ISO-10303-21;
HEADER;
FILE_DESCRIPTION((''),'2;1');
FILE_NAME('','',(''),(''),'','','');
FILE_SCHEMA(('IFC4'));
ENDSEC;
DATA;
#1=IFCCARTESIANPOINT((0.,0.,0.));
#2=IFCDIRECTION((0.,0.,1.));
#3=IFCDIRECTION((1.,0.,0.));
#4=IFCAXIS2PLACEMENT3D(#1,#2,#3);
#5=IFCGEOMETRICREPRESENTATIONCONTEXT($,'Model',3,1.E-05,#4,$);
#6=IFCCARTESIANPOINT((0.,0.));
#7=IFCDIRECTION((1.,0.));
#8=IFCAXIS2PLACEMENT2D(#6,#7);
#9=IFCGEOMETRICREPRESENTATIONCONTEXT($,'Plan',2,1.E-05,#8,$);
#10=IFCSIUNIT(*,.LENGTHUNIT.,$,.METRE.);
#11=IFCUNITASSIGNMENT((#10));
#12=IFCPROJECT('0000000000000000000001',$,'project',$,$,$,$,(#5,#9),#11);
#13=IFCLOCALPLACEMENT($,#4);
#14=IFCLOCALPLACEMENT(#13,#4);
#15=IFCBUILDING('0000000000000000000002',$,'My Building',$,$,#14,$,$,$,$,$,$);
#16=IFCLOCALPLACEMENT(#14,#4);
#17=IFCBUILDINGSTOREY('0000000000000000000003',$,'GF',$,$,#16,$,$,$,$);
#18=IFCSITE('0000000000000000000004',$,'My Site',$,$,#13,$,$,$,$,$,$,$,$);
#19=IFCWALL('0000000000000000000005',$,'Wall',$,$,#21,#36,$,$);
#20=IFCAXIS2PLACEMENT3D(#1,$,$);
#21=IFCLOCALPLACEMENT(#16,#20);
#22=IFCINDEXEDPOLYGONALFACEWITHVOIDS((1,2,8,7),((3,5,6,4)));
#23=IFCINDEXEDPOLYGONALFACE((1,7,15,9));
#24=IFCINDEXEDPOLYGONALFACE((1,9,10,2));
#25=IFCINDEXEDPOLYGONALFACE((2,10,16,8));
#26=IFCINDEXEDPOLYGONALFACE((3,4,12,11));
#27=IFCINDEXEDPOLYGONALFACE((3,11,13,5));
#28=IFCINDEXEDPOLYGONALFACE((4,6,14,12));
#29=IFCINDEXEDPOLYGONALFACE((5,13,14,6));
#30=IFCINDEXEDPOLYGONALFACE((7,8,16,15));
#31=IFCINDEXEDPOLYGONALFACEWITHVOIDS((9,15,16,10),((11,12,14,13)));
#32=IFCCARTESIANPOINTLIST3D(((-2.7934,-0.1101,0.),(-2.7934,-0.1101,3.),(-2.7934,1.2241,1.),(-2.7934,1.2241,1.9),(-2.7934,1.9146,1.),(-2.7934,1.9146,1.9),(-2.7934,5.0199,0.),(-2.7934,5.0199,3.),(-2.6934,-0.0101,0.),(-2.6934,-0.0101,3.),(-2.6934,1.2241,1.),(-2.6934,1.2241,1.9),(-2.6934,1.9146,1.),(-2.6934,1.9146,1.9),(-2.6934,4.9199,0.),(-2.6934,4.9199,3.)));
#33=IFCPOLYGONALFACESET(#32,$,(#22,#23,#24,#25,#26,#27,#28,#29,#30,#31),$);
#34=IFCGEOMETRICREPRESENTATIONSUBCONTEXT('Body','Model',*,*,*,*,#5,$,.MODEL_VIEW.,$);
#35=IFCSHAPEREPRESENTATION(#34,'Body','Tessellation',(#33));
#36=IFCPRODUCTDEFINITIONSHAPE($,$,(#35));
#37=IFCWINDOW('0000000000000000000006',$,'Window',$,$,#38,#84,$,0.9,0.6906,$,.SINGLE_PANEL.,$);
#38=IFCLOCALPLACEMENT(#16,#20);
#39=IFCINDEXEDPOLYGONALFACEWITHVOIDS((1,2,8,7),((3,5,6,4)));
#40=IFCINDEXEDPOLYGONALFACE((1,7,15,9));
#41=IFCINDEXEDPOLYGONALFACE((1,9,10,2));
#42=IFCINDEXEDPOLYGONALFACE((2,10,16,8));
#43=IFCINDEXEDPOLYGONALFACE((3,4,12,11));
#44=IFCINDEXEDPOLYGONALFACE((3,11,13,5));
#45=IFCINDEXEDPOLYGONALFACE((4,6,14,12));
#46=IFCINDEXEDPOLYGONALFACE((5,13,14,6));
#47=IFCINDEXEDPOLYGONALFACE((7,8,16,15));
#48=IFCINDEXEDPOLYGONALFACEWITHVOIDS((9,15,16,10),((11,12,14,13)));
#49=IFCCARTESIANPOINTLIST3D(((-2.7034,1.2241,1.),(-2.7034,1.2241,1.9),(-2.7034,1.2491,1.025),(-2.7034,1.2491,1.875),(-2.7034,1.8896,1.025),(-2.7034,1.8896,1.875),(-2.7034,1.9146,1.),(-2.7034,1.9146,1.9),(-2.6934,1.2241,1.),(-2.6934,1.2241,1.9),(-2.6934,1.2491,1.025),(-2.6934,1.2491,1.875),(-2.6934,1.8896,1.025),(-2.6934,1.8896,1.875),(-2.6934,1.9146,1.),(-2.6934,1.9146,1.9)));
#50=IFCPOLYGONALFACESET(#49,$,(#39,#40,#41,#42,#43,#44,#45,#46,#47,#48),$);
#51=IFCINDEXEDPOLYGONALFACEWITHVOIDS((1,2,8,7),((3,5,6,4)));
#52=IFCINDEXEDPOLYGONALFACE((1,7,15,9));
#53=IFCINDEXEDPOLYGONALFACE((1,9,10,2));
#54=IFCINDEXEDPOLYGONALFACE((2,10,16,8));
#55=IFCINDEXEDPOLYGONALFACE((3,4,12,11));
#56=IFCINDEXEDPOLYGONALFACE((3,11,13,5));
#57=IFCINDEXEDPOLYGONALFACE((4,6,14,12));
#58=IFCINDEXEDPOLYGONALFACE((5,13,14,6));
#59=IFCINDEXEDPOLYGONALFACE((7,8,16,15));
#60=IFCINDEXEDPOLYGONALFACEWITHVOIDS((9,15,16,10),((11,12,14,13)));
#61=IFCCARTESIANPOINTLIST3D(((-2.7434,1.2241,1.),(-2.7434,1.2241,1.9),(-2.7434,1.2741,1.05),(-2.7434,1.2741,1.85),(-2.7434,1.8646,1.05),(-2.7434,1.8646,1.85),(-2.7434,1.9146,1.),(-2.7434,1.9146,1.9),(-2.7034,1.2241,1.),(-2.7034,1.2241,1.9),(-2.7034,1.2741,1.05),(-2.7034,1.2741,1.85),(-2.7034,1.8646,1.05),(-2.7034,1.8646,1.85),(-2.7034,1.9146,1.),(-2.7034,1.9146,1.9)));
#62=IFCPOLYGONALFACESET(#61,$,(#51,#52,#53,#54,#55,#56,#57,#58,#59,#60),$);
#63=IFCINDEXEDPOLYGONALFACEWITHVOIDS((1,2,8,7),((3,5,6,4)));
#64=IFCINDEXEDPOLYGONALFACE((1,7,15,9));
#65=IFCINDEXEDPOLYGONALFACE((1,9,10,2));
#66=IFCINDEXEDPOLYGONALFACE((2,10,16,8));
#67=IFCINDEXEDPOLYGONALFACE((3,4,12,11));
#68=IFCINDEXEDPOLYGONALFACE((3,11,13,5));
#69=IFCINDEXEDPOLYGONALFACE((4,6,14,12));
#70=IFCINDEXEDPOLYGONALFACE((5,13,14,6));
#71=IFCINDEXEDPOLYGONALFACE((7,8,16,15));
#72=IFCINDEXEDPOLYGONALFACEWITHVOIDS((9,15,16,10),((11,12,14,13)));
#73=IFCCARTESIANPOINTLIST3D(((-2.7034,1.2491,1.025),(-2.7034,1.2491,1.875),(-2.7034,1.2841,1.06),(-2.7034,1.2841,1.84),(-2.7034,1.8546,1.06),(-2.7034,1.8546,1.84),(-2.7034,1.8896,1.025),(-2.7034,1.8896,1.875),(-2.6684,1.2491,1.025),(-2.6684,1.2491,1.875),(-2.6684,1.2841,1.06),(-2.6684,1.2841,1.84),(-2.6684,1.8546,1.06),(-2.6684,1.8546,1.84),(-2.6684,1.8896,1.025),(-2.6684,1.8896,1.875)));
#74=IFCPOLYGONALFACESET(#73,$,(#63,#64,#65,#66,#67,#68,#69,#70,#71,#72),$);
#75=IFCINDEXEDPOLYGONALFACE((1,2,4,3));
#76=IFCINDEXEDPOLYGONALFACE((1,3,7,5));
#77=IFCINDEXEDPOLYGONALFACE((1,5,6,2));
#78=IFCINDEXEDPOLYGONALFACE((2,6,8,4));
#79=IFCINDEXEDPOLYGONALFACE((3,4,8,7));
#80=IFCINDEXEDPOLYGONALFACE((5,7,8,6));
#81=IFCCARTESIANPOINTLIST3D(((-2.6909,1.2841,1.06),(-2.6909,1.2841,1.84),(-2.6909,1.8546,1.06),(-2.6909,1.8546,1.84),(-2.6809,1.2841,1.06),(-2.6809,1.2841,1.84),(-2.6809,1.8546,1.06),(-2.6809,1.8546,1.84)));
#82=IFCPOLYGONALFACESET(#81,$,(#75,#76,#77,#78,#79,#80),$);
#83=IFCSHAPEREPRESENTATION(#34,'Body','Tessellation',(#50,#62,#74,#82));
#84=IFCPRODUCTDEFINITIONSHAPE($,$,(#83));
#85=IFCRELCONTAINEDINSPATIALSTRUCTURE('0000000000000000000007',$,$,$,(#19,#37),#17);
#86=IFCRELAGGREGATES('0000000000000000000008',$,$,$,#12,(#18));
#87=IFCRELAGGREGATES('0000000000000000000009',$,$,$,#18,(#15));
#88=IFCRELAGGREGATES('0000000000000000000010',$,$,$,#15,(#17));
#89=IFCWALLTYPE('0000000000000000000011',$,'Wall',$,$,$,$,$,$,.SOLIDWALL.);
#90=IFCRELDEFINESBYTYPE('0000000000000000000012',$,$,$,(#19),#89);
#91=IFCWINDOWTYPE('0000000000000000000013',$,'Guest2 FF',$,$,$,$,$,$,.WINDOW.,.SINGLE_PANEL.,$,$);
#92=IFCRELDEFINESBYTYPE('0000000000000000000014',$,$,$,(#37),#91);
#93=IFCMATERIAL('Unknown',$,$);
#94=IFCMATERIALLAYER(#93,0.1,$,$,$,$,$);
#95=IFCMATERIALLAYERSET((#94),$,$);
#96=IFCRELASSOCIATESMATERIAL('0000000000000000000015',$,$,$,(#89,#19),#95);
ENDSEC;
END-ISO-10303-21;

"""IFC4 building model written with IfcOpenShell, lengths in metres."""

from ifc_helpers import new_model, entity, si_unit, frame, origin_with_axes, origin_2d_with_axis, place, context, subcontext, project, spatial, line, indexed_curve, outline, extrude, shape, source, transform, mapped, material, layer, layer_set, layer_usage, type_object, type_shapes, element, fill, save


model = new_model("IFC4")

# Units and contexts
model_context = context("Model", 3, precision=1e-05, world=origin_with_axes())
plan_context = context("Plan", 2, precision=1e-05, world=origin_2d_with_axis())
body_context_1 = subcontext(model_context, "Body", "Model", "MODEL_VIEW")
body_context_2 = subcontext(plan_context, "Body", "Plan", "PLAN_VIEW")
ifc_project = project(units=[si_unit("LENGTHUNIT", "METRE")], contexts=[model_context, plan_context])

# Site, building, storey
site_placement = place(None, origin_with_axes())
site = spatial("IfcSite", under=ifc_project, at=site_placement, Name="My Site")
building_placement = place(site_placement, origin_with_axes())
building = spatial("IfcBuilding", under=site, at=building_placement, Name="My Building")
storey_placement = place(building_placement, origin_with_axes())
storey = spatial("IfcBuildingStorey", under=building, at=storey_placement, Name="GF")

# Shared definitions
ifc_material_1 = material(Name="Unknown")

# Shared definitions
ifc_layer_1 = layer(ifc_material_1, 0.1)
ifc_layer_set_1 = layer_set([ifc_layer_1])
wall_type = type_object("IfcWallType", Name="Wall", PredefinedType="SOLIDWALL", material=ifc_layer_set_1)

# Wall, opening, window
ifc_layer_usage_1 = layer_usage(ifc_layer_set_1, "AXIS2", "POSITIVE", 0.0)
wall_1_placement = place(storey_placement, frame((-2.7934, 5.0199, 0.0), z_axis=(0.0, 0.0, 1.0), x_axis=(0.0, -1.0, 0.0)))
wall_1 = element("IfcWall", 1, at=wall_1_placement, inside=storey, type_object=wall_type, material=ifc_layer_usage_1, Name="Wall", context=body_context_1, shape_type="SweptSolid", body=[
    extrude(outline(indexed_curve([(0.0, 0.0), (0.1, 0.1), (5.03, 0.1), (5.13, 0.0)], segments=[line(1, 2, 3, 4, 1)])), origin_with_axes(), (0.0, 0.0, 1.0), 3.0),
])
shared_shape_1 = source(origin_with_axes(), body_context_1, "Body", "SweptSolid", [
    extrude(outline(indexed_curve([(0.0, 0.0), (0.6906, 0.0), (0.6906, 0.9), (0.0, 0.9)], segments=[line(1, 2, 3, 4, 1)])), frame((0.0, -0.6, 0.0), z_axis=(0.0, -1.0, 0.0), x_axis=(1.0, 0.0, 0.0)), (0.0, 0.0, -1.0), 1.2),
])
opening_1_placement = place(wall_1_placement, frame((3.1053, 0.0, 1.0), z_axis=(0.0, 0.0, 1.0), x_axis=(1.0, 0.0, 0.0)))
opening_1 = element("IfcOpeningElement", 2, at=opening_1_placement, cuts=wall_1, PredefinedType="OPENING", context=body_context_1, shape_type="MappedRepresentation", body=[
    mapped(shared_shape_1, transform((0.0, 0.0, 0.0), x_axis=(1.0, 0.0, 0.0), y_axis=(0.0, 1.0, 0.0), z_axis=(0.0, 0.0, 1.0), scale=1.0)),
])
window_type_1 = type_object("IfcWindowType", Name="Guest2 FF", PartitioningType="SINGLE_PANEL", PredefinedType="WINDOW")
shared_shape_2 = source(origin_with_axes(), body_context_1, "Body", "SweptSolid", [
    extrude(outline(indexed_curve([(0.0, 0.0), (0.6906, 0.0), (0.6906, 0.9), (0.0, 0.9)], segments=[line(1, 2, 3, 4, 1)]), holes=[indexed_curve([(0.025, 0.025), (0.6656, 0.025), (0.6656, 0.875), (0.025, 0.875)], segments=[line(1, 2, 3, 4, 1)])]), frame((0.0, 0.09, 0.0), z_axis=(0.0, -1.0, 0.0), x_axis=(1.0, 0.0, 0.0)), (0.0, 0.0, -1.0), 0.01),
    extrude(outline(indexed_curve([(0.0, 0.0), (0.6906, 0.0), (0.6906, 0.9), (0.0, 0.9)], segments=[line(1, 2, 3, 4, 1)]), holes=[indexed_curve([(0.05, 0.05), (0.6406, 0.05), (0.6406, 0.85), (0.05, 0.85)], segments=[line(1, 2, 3, 4, 1)])]), frame((0.0, 0.05, 0.0), z_axis=(0.0, -1.0, 0.0), x_axis=(1.0, 0.0, 0.0)), (0.0, 0.0, -1.0), 0.04),
    extrude(outline(indexed_curve([(0.0, 0.0), (0.6406, 0.0), (0.6406, 0.85), (0.0, 0.85)], segments=[line(1, 2, 3, 4, 1)]), holes=[indexed_curve([(0.035, 0.035), (0.6056, 0.035), (0.6056, 0.815), (0.035, 0.815)], segments=[line(1, 2, 3, 4, 1)])]), frame((0.025, 0.09, 0.025), z_axis=(0.0, -1.0, 0.0), x_axis=(1.0, 0.0, 0.0)), (0.0, 0.0, -1.0), 0.035),
    extrude(outline(indexed_curve([(0.035, 0.035), (0.6056, 0.035), (0.6056, 0.815), (0.035, 0.815)], segments=[line(1, 2, 3, 4, 1)])), frame((0.025, 0.1025, 0.025), z_axis=(0.0, -1.0, 0.0), x_axis=(1.0, 0.0, 0.0)), (0.0, 0.0, -1.0), 0.01),
])
shared_shape_3 = source(origin_with_axes(), body_context_2, "Body", "Curve2D", [
    entity("IfcIndexedPolyCurve", entity("IfcCartesianPointList2D", [[0.05, 0.05], [0.6406, 0.05]])),
    entity("IfcIndexedPolyCurve", entity("IfcCartesianPointList2D", [[0.0, 0.1], [0.025, 0.1], [0.025, 0.09], [0.05, 0.09], [0.05, 0.05], [0.0, 0.05]]), [entity("IfcLineIndex", [1, 2, 3, 4, 5, 6, 1])]),
    entity("IfcIndexedPolyCurve", entity("IfcCartesianPointList2D", [[0.6906, 0.1], [0.6656, 0.1], [0.6656, 0.09], [0.6406, 0.09], [0.6406, 0.05], [0.6906, 0.05]]), [entity("IfcLineIndex", [1, 2, 3, 4, 5, 6, 1])]),
    entity("IfcIndexedPolyCurve", entity("IfcCartesianPointList2D", [[0.025, 0.09], [0.06, 0.09], [0.06, 0.125], [0.025, 0.125]]), [entity("IfcLineIndex", [1, 2, 3, 4, 1])]),
    entity("IfcIndexedPolyCurve", entity("IfcCartesianPointList2D", [[0.6656, 0.09], [0.6306, 0.09], [0.6306, 0.125], [0.6656, 0.125]]), [entity("IfcLineIndex", [1, 2, 3, 4, 1])]),
    entity("IfcIndexedPolyCurve", entity("IfcCartesianPointList2D", [[0.06, 0.09], [0.6306, 0.09]])),
    entity("IfcIndexedPolyCurve", entity("IfcCartesianPointList2D", [[0.06, 0.125], [0.6306, 0.125]])),
    entity("IfcIndexedPolyCurve", entity("IfcCartesianPointList2D", [[0.06, 0.1075], [0.6306, 0.1075]])),
])
type_shapes(window_type_1, [shared_shape_2, shared_shape_3])
window_1_placement = place(opening_1_placement, frame((0.0, 0.0, 0.0), z_axis=(0.0, 0.0, 1.0), x_axis=(1.0, 0.0, 0.0)))
window_1 = element("IfcWindow", 3, at=window_1_placement, inside=storey, type_object=window_type_1, Name="Window", OverallHeight=0.9, OverallWidth=0.6906, PartitioningType="SINGLE_PANEL", shapes=[
    shape(body_context_1, "Body", "MappedRepresentation", [mapped(shared_shape_2, transform((0.0, 0.0, 0.0), x_axis=(1.0, 0.0, 0.0), y_axis=(0.0, 1.0, 0.0), z_axis=(0.0, 0.0, 1.0), scale=1.0))]),
    shape(body_context_2, "Body", "MappedRepresentation", [mapped(shared_shape_3, transform((0.0, 0.0, 0.0), x_axis=(1.0, 0.0, 0.0), y_axis=(0.0, 1.0, 0.0), z_axis=(0.0, 0.0, 1.0), scale=1.0))]),
])
fill(opening_1, window_1)

save(model, "model.ifc")
